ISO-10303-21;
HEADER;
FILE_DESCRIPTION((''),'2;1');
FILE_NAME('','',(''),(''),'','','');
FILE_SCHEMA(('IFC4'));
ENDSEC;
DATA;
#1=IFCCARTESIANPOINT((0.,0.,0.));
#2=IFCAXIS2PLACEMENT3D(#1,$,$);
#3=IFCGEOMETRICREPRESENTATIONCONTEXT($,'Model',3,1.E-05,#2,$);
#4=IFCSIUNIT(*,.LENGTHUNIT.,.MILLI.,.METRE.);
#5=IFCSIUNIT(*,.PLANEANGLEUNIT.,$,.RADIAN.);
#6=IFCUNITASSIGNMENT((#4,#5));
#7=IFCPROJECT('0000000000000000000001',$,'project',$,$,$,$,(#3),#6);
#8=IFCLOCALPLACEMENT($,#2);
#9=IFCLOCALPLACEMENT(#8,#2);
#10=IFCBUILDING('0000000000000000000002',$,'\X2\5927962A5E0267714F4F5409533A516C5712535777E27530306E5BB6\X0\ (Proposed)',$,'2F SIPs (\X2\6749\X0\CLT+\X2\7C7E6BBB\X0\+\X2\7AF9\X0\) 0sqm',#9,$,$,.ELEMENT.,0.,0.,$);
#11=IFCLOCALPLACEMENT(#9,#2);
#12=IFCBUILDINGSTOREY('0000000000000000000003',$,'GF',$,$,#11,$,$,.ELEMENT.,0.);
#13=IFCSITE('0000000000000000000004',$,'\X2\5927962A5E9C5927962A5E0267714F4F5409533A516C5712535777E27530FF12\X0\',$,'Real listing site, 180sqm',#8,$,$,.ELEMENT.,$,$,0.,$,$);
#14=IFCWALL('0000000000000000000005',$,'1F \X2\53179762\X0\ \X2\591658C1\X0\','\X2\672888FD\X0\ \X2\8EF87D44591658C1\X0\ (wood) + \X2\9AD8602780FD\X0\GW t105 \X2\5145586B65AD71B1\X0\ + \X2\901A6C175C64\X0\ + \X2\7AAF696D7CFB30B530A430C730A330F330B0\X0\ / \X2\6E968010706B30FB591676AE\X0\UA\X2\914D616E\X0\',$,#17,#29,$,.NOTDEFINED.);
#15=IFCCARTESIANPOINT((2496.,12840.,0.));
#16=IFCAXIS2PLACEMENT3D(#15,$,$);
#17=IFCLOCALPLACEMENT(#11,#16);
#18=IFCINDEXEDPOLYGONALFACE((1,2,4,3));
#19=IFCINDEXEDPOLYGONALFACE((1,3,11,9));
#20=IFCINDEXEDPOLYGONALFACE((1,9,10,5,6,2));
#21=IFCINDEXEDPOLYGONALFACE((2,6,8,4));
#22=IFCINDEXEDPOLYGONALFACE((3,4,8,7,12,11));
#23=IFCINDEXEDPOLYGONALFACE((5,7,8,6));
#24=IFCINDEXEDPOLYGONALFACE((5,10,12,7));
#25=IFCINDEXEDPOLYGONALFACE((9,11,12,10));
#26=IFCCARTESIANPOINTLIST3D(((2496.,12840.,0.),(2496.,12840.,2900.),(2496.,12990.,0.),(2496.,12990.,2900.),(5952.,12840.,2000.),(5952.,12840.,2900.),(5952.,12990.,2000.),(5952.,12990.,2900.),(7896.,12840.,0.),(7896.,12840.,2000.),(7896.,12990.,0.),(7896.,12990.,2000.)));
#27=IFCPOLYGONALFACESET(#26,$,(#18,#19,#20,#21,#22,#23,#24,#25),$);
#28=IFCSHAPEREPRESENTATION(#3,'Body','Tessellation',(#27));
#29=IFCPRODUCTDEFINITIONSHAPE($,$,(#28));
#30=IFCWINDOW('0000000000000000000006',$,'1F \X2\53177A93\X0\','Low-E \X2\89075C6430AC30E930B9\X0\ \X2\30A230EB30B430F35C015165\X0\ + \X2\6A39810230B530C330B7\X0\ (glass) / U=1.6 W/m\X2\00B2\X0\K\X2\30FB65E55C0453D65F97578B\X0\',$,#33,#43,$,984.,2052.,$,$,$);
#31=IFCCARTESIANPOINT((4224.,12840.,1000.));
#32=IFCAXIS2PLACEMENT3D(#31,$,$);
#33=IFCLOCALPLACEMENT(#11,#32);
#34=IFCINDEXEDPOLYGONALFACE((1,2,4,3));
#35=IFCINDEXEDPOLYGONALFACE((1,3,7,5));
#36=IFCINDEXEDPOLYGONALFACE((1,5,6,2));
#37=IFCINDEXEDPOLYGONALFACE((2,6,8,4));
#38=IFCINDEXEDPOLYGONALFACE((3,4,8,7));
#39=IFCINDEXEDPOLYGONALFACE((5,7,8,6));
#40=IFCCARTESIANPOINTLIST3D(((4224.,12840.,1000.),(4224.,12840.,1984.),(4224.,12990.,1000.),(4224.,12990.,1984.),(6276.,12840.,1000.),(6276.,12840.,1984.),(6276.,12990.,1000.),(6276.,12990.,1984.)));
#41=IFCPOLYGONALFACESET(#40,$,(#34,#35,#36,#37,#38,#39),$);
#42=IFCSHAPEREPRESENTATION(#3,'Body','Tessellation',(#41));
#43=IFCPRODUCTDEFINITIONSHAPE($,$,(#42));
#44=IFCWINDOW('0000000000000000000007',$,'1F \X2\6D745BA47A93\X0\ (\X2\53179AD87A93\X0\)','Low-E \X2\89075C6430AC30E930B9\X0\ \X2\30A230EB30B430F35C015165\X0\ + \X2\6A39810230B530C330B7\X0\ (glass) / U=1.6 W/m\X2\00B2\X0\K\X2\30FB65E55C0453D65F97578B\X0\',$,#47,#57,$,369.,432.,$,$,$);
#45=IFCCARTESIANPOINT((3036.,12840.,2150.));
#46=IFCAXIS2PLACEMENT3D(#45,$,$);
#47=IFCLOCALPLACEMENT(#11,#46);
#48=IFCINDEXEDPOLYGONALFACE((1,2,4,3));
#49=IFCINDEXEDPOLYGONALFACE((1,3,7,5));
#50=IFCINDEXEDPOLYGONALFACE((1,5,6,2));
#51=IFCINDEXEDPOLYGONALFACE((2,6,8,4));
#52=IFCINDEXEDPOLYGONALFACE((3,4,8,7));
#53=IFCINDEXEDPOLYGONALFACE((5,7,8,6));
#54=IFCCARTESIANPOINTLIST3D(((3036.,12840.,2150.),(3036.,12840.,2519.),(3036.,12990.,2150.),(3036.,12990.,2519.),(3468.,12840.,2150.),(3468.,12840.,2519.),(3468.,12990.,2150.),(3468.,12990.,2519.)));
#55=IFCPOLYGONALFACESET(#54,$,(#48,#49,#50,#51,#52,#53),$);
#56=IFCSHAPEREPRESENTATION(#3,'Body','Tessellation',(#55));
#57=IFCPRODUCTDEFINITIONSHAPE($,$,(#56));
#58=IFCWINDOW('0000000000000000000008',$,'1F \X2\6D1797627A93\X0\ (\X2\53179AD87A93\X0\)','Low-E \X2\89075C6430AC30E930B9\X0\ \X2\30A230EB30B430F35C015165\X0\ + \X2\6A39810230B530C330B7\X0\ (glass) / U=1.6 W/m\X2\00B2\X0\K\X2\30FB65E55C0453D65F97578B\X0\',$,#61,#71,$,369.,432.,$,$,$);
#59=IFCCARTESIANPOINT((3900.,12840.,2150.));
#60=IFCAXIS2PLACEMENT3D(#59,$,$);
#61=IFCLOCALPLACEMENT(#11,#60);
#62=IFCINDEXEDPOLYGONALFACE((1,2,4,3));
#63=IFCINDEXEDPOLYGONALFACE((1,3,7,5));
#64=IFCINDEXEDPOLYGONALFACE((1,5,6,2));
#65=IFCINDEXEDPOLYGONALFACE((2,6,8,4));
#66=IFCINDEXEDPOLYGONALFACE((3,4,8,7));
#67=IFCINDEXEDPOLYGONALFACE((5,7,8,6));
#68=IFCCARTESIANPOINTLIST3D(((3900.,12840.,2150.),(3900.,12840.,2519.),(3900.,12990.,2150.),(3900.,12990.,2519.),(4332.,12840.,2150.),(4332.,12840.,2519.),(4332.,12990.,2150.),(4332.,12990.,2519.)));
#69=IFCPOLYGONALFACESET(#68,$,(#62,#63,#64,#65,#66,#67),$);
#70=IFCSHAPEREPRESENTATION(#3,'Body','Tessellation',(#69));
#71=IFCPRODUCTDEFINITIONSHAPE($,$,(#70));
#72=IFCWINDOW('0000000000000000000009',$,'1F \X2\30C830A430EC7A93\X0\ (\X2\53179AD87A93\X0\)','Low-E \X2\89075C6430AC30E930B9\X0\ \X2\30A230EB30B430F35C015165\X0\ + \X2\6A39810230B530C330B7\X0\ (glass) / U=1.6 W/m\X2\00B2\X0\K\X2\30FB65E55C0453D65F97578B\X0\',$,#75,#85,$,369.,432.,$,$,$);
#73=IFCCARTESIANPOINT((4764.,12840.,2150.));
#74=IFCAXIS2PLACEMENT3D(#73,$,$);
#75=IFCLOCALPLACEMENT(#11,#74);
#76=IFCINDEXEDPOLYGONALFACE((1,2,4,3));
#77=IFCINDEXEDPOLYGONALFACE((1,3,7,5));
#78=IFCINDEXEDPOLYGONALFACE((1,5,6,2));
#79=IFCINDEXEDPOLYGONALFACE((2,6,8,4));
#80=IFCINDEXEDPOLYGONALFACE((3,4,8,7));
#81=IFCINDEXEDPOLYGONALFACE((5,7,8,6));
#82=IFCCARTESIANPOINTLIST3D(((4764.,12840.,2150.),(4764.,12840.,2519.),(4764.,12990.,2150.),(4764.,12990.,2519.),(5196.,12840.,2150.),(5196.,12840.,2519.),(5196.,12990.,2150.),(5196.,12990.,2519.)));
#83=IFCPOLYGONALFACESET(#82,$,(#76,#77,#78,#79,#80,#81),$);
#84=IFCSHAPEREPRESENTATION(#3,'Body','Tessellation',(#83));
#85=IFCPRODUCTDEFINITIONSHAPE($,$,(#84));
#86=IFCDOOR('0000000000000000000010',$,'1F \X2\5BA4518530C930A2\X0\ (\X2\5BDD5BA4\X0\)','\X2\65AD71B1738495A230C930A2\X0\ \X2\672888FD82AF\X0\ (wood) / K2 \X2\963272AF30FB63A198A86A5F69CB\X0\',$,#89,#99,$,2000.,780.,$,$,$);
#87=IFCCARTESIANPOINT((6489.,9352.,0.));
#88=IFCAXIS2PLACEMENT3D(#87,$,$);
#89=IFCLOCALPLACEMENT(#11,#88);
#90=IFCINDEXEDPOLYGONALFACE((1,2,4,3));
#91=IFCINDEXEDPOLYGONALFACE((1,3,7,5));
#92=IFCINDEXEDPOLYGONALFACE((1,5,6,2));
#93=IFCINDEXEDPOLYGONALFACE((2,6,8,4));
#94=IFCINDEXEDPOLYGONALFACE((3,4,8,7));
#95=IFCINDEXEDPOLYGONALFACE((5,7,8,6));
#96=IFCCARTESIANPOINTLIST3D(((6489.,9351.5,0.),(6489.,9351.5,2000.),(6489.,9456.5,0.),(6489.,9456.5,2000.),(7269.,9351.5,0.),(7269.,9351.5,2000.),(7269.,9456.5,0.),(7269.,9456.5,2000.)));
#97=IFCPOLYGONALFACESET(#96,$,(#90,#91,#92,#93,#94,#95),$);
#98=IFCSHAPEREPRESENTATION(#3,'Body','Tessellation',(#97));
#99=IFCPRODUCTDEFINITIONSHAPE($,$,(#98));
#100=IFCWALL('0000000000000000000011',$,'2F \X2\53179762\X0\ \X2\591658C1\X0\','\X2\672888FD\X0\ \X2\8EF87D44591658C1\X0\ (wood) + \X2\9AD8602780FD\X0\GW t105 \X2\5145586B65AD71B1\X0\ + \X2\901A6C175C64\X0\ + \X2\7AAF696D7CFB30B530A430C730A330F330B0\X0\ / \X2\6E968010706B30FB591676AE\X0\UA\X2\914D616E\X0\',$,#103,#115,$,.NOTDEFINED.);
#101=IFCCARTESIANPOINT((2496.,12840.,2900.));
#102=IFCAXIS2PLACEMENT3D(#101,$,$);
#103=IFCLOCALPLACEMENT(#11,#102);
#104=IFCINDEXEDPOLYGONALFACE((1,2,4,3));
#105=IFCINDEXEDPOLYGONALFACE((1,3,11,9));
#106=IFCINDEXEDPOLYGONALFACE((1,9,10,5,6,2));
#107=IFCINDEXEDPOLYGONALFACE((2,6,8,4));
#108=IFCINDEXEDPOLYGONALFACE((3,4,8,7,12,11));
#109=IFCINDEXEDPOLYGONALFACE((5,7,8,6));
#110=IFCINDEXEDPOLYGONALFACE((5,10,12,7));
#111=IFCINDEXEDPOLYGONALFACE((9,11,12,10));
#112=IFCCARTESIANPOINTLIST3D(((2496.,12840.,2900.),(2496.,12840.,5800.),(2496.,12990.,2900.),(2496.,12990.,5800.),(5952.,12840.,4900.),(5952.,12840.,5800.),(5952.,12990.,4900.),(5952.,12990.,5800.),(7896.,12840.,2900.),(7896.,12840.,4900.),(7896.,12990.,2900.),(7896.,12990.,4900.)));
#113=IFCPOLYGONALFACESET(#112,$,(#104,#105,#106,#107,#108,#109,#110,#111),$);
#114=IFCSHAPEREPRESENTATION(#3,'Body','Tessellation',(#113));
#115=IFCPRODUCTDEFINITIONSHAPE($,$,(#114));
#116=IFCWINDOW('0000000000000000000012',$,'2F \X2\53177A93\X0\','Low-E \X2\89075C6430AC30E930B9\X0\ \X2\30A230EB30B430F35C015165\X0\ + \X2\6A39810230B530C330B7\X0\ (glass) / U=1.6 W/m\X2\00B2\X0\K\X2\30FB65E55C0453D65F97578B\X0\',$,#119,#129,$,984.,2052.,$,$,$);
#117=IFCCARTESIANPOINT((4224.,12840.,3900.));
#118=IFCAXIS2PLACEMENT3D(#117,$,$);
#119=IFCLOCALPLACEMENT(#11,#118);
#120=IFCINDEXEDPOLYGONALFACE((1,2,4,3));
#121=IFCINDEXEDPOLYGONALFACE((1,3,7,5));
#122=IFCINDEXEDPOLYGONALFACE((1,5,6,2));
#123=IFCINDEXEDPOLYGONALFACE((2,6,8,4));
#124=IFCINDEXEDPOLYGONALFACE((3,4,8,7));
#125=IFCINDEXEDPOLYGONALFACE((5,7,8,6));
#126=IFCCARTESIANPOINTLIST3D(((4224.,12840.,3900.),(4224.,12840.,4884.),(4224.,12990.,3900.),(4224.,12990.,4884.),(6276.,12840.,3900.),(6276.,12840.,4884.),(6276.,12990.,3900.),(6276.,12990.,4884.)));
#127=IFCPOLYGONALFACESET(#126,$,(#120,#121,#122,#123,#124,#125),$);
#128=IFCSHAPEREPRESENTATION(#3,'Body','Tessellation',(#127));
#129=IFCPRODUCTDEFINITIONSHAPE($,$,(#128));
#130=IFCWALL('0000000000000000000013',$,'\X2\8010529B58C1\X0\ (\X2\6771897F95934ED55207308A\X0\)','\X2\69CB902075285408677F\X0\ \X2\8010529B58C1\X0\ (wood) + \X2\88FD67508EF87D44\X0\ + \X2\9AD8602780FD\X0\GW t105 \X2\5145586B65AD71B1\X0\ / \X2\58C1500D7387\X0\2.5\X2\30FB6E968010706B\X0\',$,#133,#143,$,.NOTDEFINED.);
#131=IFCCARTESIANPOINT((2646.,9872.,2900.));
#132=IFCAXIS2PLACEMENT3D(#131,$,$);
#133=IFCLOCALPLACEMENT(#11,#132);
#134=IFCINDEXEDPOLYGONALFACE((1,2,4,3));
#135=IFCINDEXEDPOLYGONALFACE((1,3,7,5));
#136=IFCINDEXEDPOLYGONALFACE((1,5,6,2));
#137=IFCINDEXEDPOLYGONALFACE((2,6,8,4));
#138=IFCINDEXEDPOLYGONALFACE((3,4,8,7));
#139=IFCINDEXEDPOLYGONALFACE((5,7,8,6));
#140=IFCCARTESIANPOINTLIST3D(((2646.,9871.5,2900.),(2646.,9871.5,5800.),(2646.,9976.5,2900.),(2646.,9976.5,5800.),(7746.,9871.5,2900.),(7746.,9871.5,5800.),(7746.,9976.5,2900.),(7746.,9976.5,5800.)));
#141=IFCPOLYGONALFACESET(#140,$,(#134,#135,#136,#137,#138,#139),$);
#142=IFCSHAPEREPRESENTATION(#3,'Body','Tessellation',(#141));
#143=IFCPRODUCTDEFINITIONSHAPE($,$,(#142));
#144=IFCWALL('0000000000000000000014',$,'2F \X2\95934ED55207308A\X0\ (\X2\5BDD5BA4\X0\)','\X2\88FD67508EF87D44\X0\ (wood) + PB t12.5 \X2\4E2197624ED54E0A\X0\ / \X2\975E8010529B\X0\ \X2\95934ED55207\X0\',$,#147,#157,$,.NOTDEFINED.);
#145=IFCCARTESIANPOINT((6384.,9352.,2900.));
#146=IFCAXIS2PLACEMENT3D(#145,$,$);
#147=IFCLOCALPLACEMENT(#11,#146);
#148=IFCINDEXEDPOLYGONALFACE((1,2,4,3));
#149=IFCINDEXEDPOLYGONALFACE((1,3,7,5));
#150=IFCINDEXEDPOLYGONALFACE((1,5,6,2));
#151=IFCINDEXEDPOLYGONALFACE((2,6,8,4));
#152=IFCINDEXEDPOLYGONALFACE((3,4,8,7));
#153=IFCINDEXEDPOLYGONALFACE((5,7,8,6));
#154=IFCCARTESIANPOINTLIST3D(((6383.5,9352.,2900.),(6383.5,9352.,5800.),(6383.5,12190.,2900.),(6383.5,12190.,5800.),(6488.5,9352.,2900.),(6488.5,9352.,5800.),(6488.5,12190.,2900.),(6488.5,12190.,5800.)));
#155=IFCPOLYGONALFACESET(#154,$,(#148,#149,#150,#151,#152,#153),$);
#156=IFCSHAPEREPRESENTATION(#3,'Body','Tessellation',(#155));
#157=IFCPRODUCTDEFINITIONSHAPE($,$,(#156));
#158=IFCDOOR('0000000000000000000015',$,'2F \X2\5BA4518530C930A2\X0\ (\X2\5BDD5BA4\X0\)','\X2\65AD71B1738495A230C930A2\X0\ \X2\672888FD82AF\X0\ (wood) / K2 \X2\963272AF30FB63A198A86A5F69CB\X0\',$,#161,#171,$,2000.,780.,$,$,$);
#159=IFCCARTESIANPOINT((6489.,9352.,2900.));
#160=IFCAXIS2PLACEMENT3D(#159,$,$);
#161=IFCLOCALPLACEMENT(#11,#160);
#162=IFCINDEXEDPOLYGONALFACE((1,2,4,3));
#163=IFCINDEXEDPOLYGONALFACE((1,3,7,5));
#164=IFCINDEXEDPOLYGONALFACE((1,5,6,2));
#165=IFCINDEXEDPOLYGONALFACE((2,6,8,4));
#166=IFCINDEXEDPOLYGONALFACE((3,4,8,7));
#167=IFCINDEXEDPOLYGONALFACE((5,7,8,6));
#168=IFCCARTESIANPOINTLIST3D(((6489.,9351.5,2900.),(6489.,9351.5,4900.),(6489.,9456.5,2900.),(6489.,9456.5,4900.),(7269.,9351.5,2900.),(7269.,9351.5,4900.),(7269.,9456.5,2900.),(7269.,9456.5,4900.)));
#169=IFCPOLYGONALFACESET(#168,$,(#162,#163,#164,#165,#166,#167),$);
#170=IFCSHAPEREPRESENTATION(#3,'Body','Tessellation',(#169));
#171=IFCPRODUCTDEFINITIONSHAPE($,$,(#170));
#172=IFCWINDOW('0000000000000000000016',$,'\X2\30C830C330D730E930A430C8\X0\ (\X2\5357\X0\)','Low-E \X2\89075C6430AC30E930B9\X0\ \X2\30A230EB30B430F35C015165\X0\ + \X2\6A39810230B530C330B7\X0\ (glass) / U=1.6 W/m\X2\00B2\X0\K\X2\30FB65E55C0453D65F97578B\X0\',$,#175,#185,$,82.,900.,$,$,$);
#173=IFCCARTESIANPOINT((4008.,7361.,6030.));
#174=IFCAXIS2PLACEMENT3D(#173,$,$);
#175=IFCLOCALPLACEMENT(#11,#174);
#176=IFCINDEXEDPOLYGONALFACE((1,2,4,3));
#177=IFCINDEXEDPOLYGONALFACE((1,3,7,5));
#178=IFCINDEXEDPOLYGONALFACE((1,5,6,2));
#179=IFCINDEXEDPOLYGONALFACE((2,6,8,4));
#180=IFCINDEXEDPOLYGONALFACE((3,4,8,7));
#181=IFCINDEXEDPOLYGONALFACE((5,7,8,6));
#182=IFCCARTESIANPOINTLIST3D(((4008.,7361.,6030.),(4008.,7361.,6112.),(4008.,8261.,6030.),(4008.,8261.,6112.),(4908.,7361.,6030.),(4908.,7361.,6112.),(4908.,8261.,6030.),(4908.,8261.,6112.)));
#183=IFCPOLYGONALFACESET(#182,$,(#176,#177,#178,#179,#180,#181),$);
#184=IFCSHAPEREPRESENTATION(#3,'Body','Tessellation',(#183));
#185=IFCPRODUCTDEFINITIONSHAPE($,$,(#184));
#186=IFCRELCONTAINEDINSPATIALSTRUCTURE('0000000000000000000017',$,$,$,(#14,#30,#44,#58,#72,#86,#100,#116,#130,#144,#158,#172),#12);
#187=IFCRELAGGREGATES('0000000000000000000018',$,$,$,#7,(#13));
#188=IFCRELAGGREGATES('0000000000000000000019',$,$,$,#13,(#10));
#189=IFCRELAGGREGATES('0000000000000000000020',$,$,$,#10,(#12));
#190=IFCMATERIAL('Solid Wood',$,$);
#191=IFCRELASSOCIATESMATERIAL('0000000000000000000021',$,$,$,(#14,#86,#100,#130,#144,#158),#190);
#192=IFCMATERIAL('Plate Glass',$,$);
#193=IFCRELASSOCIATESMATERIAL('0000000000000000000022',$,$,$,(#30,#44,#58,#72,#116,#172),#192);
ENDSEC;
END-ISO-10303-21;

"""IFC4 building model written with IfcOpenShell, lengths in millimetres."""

from ifc_helpers import new_model, si_unit, frame, frame_2d, origin, place, context, project, spatial, rectangle, extrude, material, element, fill, save


model = new_model("IFC4")

# Units and contexts
model_context = context("Model", 3, precision=1e-05, world=origin())
ifc_project = project(units=[si_unit("LENGTHUNIT", "METRE", prefix="MILLI"), si_unit("PLANEANGLEUNIT", "RADIAN")], contexts=[model_context])

# Site, building, storey
site_placement = place(None, origin())
site = spatial("IfcSite", under=ifc_project, at=site_placement, Name="大阪府大阪市東住吉区公園南矢田２", ObjectType="Real listing site, 180sqm", CompositionType="ELEMENT", RefElevation=0.0)
building_placement = place(site_placement, origin())
building = spatial("IfcBuilding", under=site, at=building_placement, Name="大阪市東住吉区公園南矢田の家 (Proposed)", ObjectType="2F SIPs (杉CLT+籾殻+竹) 0sqm", CompositionType="ELEMENT", ElevationOfRefHeight=0.0, ElevationOfTerrain=0.0)
storey_placement = place(building_placement, origin())
storey = spatial("IfcBuildingStorey", under=building, at=storey_placement, Name="GF", CompositionType="ELEMENT", Elevation=0.0)

# Wall, openings, windows
ifc_material_1 = material(Name="Solid Wood")
wall_1_placement = place(storey_placement, frame((2496.0, 12840.0, 0.0)))
wall_1 = element("IfcWall", 1, at=wall_1_placement, inside=storey, material=ifc_material_1, Name="1F 北面 外壁", Description="木製 軸組外壁 (wood) + 高性能GW t105 充填断熱 + 通気層 + 窯業系サイディング / 準耐火・外皮UA配慮", PredefinedType="NOTDEFINED", context=model_context, shape_type="SweptSolid", body=[
    extrude(rectangle(XDim=5400.0, YDim=150.0, at=frame_2d((2700.0, 75.0))), frame((2496.0, 12840.0, 0.0)), (0.0, 0.0, 1.0), 2900.0),
])
opening_1_placement = place(storey_placement, frame((4224.0, 12840.0, 1000.0)))
opening_1 = element("IfcOpeningElement", 2, at=opening_1_placement, cuts=wall_1, PredefinedType="NOTDEFINED", context=model_context, shape_type="SweptSolid", body=[
    extrude(rectangle(XDim=2052.0, YDim=150.0, at=frame_2d((1026.0, 75.0))), frame((4224.0, 12840.0, 1000.0)), (0.0, 0.0, 1.0), 984.0),
])
opening_2_placement = place(storey_placement, frame((3036.0, 12840.0, 2150.0)))
opening_2 = element("IfcOpeningElement", 3, at=opening_2_placement, cuts=wall_1, PredefinedType="NOTDEFINED", context=model_context, shape_type="SweptSolid", body=[
    extrude(rectangle(XDim=432.0, YDim=150.0, at=frame_2d((216.0, 75.0))), frame((3036.0, 12840.0, 2150.0)), (0.0, 0.0, 1.0), 369.0),
])
opening_3_placement = place(storey_placement, frame((3900.0, 12840.0, 2150.0)))
opening_3 = element("IfcOpeningElement", 4, at=opening_3_placement, cuts=wall_1, PredefinedType="NOTDEFINED", context=model_context, shape_type="SweptSolid", body=[
    extrude(rectangle(XDim=432.0, YDim=150.0, at=frame_2d((216.0, 75.0))), frame((3900.0, 12840.0, 2150.0)), (0.0, 0.0, 1.0), 369.0),
])
opening_4_placement = place(storey_placement, frame((4764.0, 12840.0, 2150.0)))
opening_4 = element("IfcOpeningElement", 5, at=opening_4_placement, cuts=wall_1, PredefinedType="NOTDEFINED", context=model_context, shape_type="SweptSolid", body=[
    extrude(rectangle(XDim=432.0, YDim=150.0, at=frame_2d((216.0, 75.0))), frame((4764.0, 12840.0, 2150.0)), (0.0, 0.0, 1.0), 369.0),
])
ifc_material_2 = material(Name="Plate Glass")
window_1_placement = place(storey_placement, frame((4224.0, 12840.0, 1000.0)))
window_1 = element("IfcWindow", 6, at=window_1_placement, inside=storey, material=ifc_material_2, Name="1F 北窓", Description="Low-E 複層ガラス アルゴン封入 + 樹脂サッシ (glass) / U=1.6 W/m²K・日射取得型", OverallHeight=984.0, OverallWidth=2052.0, context=model_context, shape_type="SweptSolid", body=[
    extrude(rectangle(XDim=2052.0, YDim=150.0, at=frame_2d((1026.0, 75.0))), frame((4224.0, 12840.0, 1000.0)), (0.0, 0.0, 1.0), 984.0),
])
fill(opening_1, window_1)
window_2_placement = place(storey_placement, frame((3036.0, 12840.0, 2150.0)))
window_2 = element("IfcWindow", 7, at=window_2_placement, inside=storey, material=ifc_material_2, Name="1F 浴室窓 (北高窓)", Description="Low-E 複層ガラス アルゴン封入 + 樹脂サッシ (glass) / U=1.6 W/m²K・日射取得型", OverallHeight=369.0, OverallWidth=432.0, context=model_context, shape_type="SweptSolid", body=[
    extrude(rectangle(XDim=432.0, YDim=150.0, at=frame_2d((216.0, 75.0))), frame((3036.0, 12840.0, 2150.0)), (0.0, 0.0, 1.0), 369.0),
])
fill(opening_2, window_2)
window_3_placement = place(storey_placement, frame((3900.0, 12840.0, 2150.0)))
window_3 = element("IfcWindow", 8, at=window_3_placement, inside=storey, material=ifc_material_2, Name="1F 洗面窓 (北高窓)", Description="Low-E 複層ガラス アルゴン封入 + 樹脂サッシ (glass) / U=1.6 W/m²K・日射取得型", OverallHeight=369.0, OverallWidth=432.0, context=model_context, shape_type="SweptSolid", body=[
    extrude(rectangle(XDim=432.0, YDim=150.0, at=frame_2d((216.0, 75.0))), frame((3900.0, 12840.0, 2150.0)), (0.0, 0.0, 1.0), 369.0),
])
fill(opening_3, window_3)
window_4_placement = place(storey_placement, frame((4764.0, 12840.0, 2150.0)))
window_4 = element("IfcWindow", 9, at=window_4_placement, inside=storey, material=ifc_material_2, Name="1F トイレ窓 (北高窓)", Description="Low-E 複層ガラス アルゴン封入 + 樹脂サッシ (glass) / U=1.6 W/m²K・日射取得型", OverallHeight=369.0, OverallWidth=432.0, context=model_context, shape_type="SweptSolid", body=[
    extrude(rectangle(XDim=432.0, YDim=150.0, at=frame_2d((216.0, 75.0))), frame((4764.0, 12840.0, 2150.0)), (0.0, 0.0, 1.0), 369.0),
])
fill(opening_4, window_4)

# Door
door_1_placement = place(storey_placement, frame((6489.0, 9352.0, 0.0)))
element("IfcDoor", 10, at=door_1_placement, inside=storey, material=ifc_material_1, Name="1F 室内ドア (寝室)", Description="断熱玄関ドア 木製芯 (wood) / K2 防犯・採風機構", OverallHeight=2000.0, OverallWidth=780.0, context=model_context, shape_type="SweptSolid", body=[
    extrude(rectangle(XDim=780.0, YDim=105.0, at=frame_2d((390.0, 52.0))), frame((6489.0, 9352.0, 0.0)), (0.0, 0.0, 1.0), 2000.0),
])

# Wall, opening, window
wall_2_placement = place(storey_placement, frame((2496.0, 12840.0, 2900.0)))
wall_2 = element("IfcWall", 11, at=wall_2_placement, inside=storey, material=ifc_material_1, Name="2F 北面 外壁", Description="木製 軸組外壁 (wood) + 高性能GW t105 充填断熱 + 通気層 + 窯業系サイディング / 準耐火・外皮UA配慮", PredefinedType="NOTDEFINED", context=model_context, shape_type="SweptSolid", body=[
    extrude(rectangle(XDim=5400.0, YDim=150.0, at=frame_2d((2700.0, 75.0))), frame((2496.0, 12840.0, 2900.0)), (0.0, 0.0, 1.0), 2900.0),
])
opening_5_placement = place(storey_placement, frame((4224.0, 12840.0, 3900.0)))
opening_5 = element("IfcOpeningElement", 12, at=opening_5_placement, cuts=wall_2, PredefinedType="NOTDEFINED", context=model_context, shape_type="SweptSolid", body=[
    extrude(rectangle(XDim=2052.0, YDim=150.0, at=frame_2d((1026.0, 75.0))), frame((4224.0, 12840.0, 3900.0)), (0.0, 0.0, 1.0), 984.0),
])
window_5_placement = place(storey_placement, frame((4224.0, 12840.0, 3900.0)))
window_5 = element("IfcWindow", 13, at=window_5_placement, inside=storey, material=ifc_material_2, Name="2F 北窓", Description="Low-E 複層ガラス アルゴン封入 + 樹脂サッシ (glass) / U=1.6 W/m²K・日射取得型", OverallHeight=984.0, OverallWidth=2052.0, context=model_context, shape_type="SweptSolid", body=[
    extrude(rectangle(XDim=2052.0, YDim=150.0, at=frame_2d((1026.0, 75.0))), frame((4224.0, 12840.0, 3900.0)), (0.0, 0.0, 1.0), 984.0),
])
fill(opening_5, window_5)

# Walls
wall_3_placement = place(storey_placement, frame((2646.0, 9872.0, 2900.0)))
element("IfcWall", 14, at=wall_3_placement, inside=storey, material=ifc_material_1, Name="耐力壁 (東西間仕切り)", Description="構造用合板 耐力壁 (wood) + 製材軸組 + 高性能GW t105 充填断熱 / 壁倍率2.5・準耐火", PredefinedType="NOTDEFINED", context=model_context, shape_type="SweptSolid", body=[
    extrude(rectangle(XDim=5100.0, YDim=105.0, at=frame_2d((2550.0, 52.0))), frame((2646.0, 9872.0, 2900.0)), (0.0, 0.0, 1.0), 2900.0),
])
wall_4_placement = place(storey_placement, frame((6384.0, 9352.0, 2900.0)))
element("IfcWall", 15, at=wall_4_placement, inside=storey, material=ifc_material_1, Name="2F 間仕切り (寝室)", Description="製材軸組 (wood) + PB t12.5 両面仕上 / 非耐力 間仕切", PredefinedType="NOTDEFINED", context=model_context, shape_type="SweptSolid", body=[
    extrude(rectangle(XDim=105.0, YDim=2838.0, at=frame_2d((52.0, 1419.0))), frame((6384.0, 9352.0, 2900.0)), (0.0, 0.0, 1.0), 2900.0),
])

# Door
door_2_placement = place(storey_placement, frame((6489.0, 9352.0, 2900.0)))
element("IfcDoor", 16, at=door_2_placement, inside=storey, material=ifc_material_1, Name="2F 室内ドア (寝室)", Description="断熱玄関ドア 木製芯 (wood) / K2 防犯・採風機構", OverallHeight=2000.0, OverallWidth=780.0, context=model_context, shape_type="SweptSolid", body=[
    extrude(rectangle(XDim=780.0, YDim=105.0, at=frame_2d((390.0, 52.0))), frame((6489.0, 9352.0, 2900.0)), (0.0, 0.0, 1.0), 2000.0),
])

# Window
window_6_placement = place(storey_placement, frame((4008.0, 7361.0, 6030.0)))
element("IfcWindow", 17, at=window_6_placement, inside=storey, material=ifc_material_2, Name="トップライト (南)", Description="Low-E 複層ガラス アルゴン封入 + 樹脂サッシ (glass) / U=1.6 W/m²K・日射取得型", OverallHeight=82.0, OverallWidth=900.0, context=model_context, shape_type="SweptSolid", body=[
    extrude(rectangle(XDim=900.0, YDim=900.0, at=frame_2d((450.0, 450.0))), frame((4008.0, 7361.0, 6030.0)), (0.0, 0.0, 1.0), 82.0),
])

save(model, "model.ifc")
